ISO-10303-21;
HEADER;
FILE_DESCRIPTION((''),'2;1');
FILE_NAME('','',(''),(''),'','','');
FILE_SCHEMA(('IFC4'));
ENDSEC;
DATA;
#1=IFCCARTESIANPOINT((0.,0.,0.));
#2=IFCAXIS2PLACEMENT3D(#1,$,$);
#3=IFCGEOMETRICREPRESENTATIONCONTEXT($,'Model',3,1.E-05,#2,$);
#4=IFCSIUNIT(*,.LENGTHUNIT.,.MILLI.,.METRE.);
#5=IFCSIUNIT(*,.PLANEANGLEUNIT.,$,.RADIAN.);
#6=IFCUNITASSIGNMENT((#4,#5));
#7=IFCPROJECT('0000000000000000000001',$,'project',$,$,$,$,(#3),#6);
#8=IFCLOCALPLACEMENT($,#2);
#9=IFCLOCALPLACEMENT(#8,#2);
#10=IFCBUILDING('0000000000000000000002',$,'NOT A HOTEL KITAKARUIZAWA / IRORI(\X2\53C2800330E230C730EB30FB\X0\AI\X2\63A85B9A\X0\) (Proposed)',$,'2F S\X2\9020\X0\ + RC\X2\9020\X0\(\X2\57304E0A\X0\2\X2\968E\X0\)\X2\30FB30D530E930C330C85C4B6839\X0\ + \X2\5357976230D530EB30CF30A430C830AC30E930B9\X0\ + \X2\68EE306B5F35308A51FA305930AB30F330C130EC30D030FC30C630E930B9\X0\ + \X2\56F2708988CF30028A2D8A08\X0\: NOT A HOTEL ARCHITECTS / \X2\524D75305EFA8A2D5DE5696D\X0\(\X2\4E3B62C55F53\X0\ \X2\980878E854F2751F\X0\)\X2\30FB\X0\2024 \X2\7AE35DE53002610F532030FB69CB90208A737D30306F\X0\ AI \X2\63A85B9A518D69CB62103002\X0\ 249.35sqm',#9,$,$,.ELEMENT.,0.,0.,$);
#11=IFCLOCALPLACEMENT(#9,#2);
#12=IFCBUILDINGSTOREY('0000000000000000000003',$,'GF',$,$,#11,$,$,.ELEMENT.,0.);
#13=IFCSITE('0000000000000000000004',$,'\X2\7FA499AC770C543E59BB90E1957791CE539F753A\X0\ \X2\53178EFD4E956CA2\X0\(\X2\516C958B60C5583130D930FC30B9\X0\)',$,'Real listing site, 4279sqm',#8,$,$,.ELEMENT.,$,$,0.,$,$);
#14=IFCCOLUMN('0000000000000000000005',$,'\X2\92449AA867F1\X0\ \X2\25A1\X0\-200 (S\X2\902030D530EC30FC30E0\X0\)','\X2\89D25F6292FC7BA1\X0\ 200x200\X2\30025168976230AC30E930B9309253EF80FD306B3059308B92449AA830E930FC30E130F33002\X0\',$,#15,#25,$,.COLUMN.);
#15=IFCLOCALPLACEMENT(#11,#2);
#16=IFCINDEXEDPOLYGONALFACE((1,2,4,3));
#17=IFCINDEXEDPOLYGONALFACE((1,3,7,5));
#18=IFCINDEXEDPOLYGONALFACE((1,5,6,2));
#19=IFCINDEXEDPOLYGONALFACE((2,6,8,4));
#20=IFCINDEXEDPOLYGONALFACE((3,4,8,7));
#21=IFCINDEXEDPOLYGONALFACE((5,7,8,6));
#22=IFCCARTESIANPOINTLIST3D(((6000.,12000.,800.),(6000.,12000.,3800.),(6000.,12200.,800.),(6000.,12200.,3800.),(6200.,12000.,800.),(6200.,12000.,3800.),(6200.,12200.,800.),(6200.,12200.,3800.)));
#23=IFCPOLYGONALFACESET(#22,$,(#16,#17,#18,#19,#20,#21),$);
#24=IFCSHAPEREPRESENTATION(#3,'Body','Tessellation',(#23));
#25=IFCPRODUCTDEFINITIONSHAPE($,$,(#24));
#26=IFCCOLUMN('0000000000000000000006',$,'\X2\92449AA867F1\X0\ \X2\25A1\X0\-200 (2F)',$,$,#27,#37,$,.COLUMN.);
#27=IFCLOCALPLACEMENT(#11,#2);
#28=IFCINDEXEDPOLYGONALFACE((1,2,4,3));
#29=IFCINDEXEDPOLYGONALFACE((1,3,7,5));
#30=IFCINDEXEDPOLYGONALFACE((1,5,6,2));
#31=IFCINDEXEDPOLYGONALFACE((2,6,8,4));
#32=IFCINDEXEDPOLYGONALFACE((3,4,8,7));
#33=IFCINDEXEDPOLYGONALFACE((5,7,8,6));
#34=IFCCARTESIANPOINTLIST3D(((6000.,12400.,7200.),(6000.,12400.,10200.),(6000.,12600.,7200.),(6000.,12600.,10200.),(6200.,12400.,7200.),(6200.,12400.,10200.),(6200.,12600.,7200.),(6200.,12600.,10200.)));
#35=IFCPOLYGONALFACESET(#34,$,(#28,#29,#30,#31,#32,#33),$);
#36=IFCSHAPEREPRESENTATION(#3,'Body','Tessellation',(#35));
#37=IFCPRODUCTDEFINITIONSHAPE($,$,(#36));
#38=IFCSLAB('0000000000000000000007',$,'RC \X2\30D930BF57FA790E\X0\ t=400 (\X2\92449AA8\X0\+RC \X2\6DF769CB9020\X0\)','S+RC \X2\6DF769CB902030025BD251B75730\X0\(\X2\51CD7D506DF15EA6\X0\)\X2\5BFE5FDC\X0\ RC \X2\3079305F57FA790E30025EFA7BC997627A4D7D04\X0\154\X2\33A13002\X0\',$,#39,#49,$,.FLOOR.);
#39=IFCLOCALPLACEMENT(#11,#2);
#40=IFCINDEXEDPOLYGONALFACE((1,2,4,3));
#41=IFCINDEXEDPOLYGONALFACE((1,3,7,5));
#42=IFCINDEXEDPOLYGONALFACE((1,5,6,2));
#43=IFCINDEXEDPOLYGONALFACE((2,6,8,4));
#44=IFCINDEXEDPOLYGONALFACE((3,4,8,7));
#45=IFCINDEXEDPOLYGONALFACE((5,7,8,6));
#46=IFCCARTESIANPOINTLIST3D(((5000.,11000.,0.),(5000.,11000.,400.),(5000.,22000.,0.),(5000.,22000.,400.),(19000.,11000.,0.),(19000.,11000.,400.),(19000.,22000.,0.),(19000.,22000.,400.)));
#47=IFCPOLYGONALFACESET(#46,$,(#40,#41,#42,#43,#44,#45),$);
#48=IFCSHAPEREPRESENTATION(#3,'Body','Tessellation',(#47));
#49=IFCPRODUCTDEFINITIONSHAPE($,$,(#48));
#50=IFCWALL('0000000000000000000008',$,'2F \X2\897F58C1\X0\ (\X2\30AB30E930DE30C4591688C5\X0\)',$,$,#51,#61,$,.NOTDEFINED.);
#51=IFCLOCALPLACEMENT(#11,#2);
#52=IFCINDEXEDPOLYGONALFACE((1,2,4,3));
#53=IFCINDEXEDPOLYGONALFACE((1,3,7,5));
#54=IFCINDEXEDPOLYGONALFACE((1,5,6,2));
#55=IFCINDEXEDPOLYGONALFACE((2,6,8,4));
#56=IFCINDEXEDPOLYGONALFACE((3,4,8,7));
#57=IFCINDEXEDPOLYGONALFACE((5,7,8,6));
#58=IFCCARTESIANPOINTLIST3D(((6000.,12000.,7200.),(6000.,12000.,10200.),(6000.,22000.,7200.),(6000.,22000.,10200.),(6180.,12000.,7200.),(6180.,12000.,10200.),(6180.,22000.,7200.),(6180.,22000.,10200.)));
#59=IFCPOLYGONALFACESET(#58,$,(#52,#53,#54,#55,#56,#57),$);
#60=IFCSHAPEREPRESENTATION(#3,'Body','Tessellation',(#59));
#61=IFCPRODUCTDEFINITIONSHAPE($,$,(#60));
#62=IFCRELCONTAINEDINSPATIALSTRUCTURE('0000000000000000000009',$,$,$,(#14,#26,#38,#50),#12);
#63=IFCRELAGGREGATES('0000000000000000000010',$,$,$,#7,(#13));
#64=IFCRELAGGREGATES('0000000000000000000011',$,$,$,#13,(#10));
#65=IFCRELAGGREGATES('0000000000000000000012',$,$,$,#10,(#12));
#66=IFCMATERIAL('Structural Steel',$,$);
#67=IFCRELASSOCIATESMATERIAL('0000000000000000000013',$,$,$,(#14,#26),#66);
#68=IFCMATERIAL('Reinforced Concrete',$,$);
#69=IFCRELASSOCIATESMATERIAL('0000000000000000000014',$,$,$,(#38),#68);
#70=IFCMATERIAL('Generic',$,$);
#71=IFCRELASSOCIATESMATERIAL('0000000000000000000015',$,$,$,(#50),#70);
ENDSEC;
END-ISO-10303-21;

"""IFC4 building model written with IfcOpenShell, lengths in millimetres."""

from ifc_helpers import new_model, si_unit, frame, frame_2d, origin, place, context, project, spatial, rectangle, extrude, material, element, save


model = new_model("IFC4")

# Units and contexts
model_context = context("Model", 3, precision=1e-05, world=origin())
ifc_project = project(units=[si_unit("LENGTHUNIT", "METRE", prefix="MILLI"), si_unit("PLANEANGLEUNIT", "RADIAN")], contexts=[model_context])

# Site, building, storey
site_placement = place(None, origin())
site = spatial("IfcSite", under=ifc_project, at=site_placement, Name="群馬県吾妻郡長野原町 北軽井沢(公開情報ベース)", ObjectType="Real listing site, 4279sqm", CompositionType="ELEMENT", RefElevation=0.0)
building_placement = place(site_placement, origin())
building = spatial("IfcBuilding", under=site, at=building_placement, Name="NOT A HOTEL KITAKARUIZAWA / IRORI(参考モデル・AI推定) (Proposed)", ObjectType="2F S造 + RC造(地上2階)・フラット屋根 + 南面フルハイトガラス + 森に張り出すカンチレバーテラス + 囲炉裏。設計: NOT A HOTEL ARCHITECTS / 前田建設工業(主担当 須磨哲生)・2024 竣工。意匠・構造詳細は AI 推定再構成。 249.35sqm", CompositionType="ELEMENT", ElevationOfRefHeight=0.0, ElevationOfTerrain=0.0)
storey_placement = place(building_placement, origin())
storey = spatial("IfcBuildingStorey", under=building, at=storey_placement, Name="GF", CompositionType="ELEMENT", Elevation=0.0)

# Columns
ifc_material_1 = material(Name="Structural Steel")
column_1_placement = place(storey_placement, frame((3000.0, 6000.0, 400.0)))
element("IfcColumn", 1, at=column_1_placement, inside=storey, material=ifc_material_1, Name="鉄骨柱 □-200 (S造フレーム)", Description="角形鋼管 200x200。全面ガラスを可能にする鉄骨ラーメン。", PredefinedType="COLUMN", context=model_context, shape_type="SweptSolid", body=[
    extrude(rectangle(XDim=200.0, YDim=200.0, at=frame_2d((100.0, 100.0))), frame((3000.0, 6000.0, 400.0)), (0.0, 0.0, 1.0), 3000.0),
])
column_2_placement = place(storey_placement, frame((3000.0, 6200.0, 3600.0)))
element("IfcColumn", 2, at=column_2_placement, inside=storey, material=ifc_material_1, Name="鉄骨柱 □-200 (2F)", PredefinedType="COLUMN", context=model_context, shape_type="SweptSolid", body=[
    extrude(rectangle(XDim=200.0, YDim=200.0, at=frame_2d((100.0, 100.0))), frame((3000.0, 6200.0, 3600.0)), (0.0, 0.0, 1.0), 3000.0),
])

# Slab
ifc_material_2 = material(Name="Reinforced Concrete")
slab_1_placement = place(storey_placement, frame((2500.0, 5500.0, 0.0)))
element("IfcSlab", 3, at=slab_1_placement, inside=storey, material=ifc_material_2, Name="RC ベタ基礎 t=400 (鉄骨+RC 混構造)", Description="S+RC 混構造。寒冷地(凍結深度)対応 RC べた基礎。建築面積約154㎡。", PredefinedType="FLOOR", context=model_context, shape_type="SweptSolid", body=[
    extrude(rectangle(XDim=14000.0, YDim=11000.0, at=frame_2d((7000.0, 5500.0))), frame((2500.0, 5500.0, 0.0)), (0.0, 0.0, 1.0), 400.0),
])
ifc_material_3 = material(Name="Generic")

# Wall
wall_1_placement = place(storey_placement, frame((3000.0, 6000.0, 3600.0)))
element("IfcWall", 4, at=wall_1_placement, inside=storey, material=ifc_material_3, Name="2F 西壁 (カラマツ外装)", PredefinedType="NOTDEFINED", context=model_context, shape_type="SweptSolid", body=[
    extrude(rectangle(XDim=180.0, YDim=10000.0, at=frame_2d((90.0, 5000.0))), frame((3000.0, 6000.0, 3600.0)), (0.0, 0.0, 1.0), 3000.0),
])

save(model, "model.ifc")
